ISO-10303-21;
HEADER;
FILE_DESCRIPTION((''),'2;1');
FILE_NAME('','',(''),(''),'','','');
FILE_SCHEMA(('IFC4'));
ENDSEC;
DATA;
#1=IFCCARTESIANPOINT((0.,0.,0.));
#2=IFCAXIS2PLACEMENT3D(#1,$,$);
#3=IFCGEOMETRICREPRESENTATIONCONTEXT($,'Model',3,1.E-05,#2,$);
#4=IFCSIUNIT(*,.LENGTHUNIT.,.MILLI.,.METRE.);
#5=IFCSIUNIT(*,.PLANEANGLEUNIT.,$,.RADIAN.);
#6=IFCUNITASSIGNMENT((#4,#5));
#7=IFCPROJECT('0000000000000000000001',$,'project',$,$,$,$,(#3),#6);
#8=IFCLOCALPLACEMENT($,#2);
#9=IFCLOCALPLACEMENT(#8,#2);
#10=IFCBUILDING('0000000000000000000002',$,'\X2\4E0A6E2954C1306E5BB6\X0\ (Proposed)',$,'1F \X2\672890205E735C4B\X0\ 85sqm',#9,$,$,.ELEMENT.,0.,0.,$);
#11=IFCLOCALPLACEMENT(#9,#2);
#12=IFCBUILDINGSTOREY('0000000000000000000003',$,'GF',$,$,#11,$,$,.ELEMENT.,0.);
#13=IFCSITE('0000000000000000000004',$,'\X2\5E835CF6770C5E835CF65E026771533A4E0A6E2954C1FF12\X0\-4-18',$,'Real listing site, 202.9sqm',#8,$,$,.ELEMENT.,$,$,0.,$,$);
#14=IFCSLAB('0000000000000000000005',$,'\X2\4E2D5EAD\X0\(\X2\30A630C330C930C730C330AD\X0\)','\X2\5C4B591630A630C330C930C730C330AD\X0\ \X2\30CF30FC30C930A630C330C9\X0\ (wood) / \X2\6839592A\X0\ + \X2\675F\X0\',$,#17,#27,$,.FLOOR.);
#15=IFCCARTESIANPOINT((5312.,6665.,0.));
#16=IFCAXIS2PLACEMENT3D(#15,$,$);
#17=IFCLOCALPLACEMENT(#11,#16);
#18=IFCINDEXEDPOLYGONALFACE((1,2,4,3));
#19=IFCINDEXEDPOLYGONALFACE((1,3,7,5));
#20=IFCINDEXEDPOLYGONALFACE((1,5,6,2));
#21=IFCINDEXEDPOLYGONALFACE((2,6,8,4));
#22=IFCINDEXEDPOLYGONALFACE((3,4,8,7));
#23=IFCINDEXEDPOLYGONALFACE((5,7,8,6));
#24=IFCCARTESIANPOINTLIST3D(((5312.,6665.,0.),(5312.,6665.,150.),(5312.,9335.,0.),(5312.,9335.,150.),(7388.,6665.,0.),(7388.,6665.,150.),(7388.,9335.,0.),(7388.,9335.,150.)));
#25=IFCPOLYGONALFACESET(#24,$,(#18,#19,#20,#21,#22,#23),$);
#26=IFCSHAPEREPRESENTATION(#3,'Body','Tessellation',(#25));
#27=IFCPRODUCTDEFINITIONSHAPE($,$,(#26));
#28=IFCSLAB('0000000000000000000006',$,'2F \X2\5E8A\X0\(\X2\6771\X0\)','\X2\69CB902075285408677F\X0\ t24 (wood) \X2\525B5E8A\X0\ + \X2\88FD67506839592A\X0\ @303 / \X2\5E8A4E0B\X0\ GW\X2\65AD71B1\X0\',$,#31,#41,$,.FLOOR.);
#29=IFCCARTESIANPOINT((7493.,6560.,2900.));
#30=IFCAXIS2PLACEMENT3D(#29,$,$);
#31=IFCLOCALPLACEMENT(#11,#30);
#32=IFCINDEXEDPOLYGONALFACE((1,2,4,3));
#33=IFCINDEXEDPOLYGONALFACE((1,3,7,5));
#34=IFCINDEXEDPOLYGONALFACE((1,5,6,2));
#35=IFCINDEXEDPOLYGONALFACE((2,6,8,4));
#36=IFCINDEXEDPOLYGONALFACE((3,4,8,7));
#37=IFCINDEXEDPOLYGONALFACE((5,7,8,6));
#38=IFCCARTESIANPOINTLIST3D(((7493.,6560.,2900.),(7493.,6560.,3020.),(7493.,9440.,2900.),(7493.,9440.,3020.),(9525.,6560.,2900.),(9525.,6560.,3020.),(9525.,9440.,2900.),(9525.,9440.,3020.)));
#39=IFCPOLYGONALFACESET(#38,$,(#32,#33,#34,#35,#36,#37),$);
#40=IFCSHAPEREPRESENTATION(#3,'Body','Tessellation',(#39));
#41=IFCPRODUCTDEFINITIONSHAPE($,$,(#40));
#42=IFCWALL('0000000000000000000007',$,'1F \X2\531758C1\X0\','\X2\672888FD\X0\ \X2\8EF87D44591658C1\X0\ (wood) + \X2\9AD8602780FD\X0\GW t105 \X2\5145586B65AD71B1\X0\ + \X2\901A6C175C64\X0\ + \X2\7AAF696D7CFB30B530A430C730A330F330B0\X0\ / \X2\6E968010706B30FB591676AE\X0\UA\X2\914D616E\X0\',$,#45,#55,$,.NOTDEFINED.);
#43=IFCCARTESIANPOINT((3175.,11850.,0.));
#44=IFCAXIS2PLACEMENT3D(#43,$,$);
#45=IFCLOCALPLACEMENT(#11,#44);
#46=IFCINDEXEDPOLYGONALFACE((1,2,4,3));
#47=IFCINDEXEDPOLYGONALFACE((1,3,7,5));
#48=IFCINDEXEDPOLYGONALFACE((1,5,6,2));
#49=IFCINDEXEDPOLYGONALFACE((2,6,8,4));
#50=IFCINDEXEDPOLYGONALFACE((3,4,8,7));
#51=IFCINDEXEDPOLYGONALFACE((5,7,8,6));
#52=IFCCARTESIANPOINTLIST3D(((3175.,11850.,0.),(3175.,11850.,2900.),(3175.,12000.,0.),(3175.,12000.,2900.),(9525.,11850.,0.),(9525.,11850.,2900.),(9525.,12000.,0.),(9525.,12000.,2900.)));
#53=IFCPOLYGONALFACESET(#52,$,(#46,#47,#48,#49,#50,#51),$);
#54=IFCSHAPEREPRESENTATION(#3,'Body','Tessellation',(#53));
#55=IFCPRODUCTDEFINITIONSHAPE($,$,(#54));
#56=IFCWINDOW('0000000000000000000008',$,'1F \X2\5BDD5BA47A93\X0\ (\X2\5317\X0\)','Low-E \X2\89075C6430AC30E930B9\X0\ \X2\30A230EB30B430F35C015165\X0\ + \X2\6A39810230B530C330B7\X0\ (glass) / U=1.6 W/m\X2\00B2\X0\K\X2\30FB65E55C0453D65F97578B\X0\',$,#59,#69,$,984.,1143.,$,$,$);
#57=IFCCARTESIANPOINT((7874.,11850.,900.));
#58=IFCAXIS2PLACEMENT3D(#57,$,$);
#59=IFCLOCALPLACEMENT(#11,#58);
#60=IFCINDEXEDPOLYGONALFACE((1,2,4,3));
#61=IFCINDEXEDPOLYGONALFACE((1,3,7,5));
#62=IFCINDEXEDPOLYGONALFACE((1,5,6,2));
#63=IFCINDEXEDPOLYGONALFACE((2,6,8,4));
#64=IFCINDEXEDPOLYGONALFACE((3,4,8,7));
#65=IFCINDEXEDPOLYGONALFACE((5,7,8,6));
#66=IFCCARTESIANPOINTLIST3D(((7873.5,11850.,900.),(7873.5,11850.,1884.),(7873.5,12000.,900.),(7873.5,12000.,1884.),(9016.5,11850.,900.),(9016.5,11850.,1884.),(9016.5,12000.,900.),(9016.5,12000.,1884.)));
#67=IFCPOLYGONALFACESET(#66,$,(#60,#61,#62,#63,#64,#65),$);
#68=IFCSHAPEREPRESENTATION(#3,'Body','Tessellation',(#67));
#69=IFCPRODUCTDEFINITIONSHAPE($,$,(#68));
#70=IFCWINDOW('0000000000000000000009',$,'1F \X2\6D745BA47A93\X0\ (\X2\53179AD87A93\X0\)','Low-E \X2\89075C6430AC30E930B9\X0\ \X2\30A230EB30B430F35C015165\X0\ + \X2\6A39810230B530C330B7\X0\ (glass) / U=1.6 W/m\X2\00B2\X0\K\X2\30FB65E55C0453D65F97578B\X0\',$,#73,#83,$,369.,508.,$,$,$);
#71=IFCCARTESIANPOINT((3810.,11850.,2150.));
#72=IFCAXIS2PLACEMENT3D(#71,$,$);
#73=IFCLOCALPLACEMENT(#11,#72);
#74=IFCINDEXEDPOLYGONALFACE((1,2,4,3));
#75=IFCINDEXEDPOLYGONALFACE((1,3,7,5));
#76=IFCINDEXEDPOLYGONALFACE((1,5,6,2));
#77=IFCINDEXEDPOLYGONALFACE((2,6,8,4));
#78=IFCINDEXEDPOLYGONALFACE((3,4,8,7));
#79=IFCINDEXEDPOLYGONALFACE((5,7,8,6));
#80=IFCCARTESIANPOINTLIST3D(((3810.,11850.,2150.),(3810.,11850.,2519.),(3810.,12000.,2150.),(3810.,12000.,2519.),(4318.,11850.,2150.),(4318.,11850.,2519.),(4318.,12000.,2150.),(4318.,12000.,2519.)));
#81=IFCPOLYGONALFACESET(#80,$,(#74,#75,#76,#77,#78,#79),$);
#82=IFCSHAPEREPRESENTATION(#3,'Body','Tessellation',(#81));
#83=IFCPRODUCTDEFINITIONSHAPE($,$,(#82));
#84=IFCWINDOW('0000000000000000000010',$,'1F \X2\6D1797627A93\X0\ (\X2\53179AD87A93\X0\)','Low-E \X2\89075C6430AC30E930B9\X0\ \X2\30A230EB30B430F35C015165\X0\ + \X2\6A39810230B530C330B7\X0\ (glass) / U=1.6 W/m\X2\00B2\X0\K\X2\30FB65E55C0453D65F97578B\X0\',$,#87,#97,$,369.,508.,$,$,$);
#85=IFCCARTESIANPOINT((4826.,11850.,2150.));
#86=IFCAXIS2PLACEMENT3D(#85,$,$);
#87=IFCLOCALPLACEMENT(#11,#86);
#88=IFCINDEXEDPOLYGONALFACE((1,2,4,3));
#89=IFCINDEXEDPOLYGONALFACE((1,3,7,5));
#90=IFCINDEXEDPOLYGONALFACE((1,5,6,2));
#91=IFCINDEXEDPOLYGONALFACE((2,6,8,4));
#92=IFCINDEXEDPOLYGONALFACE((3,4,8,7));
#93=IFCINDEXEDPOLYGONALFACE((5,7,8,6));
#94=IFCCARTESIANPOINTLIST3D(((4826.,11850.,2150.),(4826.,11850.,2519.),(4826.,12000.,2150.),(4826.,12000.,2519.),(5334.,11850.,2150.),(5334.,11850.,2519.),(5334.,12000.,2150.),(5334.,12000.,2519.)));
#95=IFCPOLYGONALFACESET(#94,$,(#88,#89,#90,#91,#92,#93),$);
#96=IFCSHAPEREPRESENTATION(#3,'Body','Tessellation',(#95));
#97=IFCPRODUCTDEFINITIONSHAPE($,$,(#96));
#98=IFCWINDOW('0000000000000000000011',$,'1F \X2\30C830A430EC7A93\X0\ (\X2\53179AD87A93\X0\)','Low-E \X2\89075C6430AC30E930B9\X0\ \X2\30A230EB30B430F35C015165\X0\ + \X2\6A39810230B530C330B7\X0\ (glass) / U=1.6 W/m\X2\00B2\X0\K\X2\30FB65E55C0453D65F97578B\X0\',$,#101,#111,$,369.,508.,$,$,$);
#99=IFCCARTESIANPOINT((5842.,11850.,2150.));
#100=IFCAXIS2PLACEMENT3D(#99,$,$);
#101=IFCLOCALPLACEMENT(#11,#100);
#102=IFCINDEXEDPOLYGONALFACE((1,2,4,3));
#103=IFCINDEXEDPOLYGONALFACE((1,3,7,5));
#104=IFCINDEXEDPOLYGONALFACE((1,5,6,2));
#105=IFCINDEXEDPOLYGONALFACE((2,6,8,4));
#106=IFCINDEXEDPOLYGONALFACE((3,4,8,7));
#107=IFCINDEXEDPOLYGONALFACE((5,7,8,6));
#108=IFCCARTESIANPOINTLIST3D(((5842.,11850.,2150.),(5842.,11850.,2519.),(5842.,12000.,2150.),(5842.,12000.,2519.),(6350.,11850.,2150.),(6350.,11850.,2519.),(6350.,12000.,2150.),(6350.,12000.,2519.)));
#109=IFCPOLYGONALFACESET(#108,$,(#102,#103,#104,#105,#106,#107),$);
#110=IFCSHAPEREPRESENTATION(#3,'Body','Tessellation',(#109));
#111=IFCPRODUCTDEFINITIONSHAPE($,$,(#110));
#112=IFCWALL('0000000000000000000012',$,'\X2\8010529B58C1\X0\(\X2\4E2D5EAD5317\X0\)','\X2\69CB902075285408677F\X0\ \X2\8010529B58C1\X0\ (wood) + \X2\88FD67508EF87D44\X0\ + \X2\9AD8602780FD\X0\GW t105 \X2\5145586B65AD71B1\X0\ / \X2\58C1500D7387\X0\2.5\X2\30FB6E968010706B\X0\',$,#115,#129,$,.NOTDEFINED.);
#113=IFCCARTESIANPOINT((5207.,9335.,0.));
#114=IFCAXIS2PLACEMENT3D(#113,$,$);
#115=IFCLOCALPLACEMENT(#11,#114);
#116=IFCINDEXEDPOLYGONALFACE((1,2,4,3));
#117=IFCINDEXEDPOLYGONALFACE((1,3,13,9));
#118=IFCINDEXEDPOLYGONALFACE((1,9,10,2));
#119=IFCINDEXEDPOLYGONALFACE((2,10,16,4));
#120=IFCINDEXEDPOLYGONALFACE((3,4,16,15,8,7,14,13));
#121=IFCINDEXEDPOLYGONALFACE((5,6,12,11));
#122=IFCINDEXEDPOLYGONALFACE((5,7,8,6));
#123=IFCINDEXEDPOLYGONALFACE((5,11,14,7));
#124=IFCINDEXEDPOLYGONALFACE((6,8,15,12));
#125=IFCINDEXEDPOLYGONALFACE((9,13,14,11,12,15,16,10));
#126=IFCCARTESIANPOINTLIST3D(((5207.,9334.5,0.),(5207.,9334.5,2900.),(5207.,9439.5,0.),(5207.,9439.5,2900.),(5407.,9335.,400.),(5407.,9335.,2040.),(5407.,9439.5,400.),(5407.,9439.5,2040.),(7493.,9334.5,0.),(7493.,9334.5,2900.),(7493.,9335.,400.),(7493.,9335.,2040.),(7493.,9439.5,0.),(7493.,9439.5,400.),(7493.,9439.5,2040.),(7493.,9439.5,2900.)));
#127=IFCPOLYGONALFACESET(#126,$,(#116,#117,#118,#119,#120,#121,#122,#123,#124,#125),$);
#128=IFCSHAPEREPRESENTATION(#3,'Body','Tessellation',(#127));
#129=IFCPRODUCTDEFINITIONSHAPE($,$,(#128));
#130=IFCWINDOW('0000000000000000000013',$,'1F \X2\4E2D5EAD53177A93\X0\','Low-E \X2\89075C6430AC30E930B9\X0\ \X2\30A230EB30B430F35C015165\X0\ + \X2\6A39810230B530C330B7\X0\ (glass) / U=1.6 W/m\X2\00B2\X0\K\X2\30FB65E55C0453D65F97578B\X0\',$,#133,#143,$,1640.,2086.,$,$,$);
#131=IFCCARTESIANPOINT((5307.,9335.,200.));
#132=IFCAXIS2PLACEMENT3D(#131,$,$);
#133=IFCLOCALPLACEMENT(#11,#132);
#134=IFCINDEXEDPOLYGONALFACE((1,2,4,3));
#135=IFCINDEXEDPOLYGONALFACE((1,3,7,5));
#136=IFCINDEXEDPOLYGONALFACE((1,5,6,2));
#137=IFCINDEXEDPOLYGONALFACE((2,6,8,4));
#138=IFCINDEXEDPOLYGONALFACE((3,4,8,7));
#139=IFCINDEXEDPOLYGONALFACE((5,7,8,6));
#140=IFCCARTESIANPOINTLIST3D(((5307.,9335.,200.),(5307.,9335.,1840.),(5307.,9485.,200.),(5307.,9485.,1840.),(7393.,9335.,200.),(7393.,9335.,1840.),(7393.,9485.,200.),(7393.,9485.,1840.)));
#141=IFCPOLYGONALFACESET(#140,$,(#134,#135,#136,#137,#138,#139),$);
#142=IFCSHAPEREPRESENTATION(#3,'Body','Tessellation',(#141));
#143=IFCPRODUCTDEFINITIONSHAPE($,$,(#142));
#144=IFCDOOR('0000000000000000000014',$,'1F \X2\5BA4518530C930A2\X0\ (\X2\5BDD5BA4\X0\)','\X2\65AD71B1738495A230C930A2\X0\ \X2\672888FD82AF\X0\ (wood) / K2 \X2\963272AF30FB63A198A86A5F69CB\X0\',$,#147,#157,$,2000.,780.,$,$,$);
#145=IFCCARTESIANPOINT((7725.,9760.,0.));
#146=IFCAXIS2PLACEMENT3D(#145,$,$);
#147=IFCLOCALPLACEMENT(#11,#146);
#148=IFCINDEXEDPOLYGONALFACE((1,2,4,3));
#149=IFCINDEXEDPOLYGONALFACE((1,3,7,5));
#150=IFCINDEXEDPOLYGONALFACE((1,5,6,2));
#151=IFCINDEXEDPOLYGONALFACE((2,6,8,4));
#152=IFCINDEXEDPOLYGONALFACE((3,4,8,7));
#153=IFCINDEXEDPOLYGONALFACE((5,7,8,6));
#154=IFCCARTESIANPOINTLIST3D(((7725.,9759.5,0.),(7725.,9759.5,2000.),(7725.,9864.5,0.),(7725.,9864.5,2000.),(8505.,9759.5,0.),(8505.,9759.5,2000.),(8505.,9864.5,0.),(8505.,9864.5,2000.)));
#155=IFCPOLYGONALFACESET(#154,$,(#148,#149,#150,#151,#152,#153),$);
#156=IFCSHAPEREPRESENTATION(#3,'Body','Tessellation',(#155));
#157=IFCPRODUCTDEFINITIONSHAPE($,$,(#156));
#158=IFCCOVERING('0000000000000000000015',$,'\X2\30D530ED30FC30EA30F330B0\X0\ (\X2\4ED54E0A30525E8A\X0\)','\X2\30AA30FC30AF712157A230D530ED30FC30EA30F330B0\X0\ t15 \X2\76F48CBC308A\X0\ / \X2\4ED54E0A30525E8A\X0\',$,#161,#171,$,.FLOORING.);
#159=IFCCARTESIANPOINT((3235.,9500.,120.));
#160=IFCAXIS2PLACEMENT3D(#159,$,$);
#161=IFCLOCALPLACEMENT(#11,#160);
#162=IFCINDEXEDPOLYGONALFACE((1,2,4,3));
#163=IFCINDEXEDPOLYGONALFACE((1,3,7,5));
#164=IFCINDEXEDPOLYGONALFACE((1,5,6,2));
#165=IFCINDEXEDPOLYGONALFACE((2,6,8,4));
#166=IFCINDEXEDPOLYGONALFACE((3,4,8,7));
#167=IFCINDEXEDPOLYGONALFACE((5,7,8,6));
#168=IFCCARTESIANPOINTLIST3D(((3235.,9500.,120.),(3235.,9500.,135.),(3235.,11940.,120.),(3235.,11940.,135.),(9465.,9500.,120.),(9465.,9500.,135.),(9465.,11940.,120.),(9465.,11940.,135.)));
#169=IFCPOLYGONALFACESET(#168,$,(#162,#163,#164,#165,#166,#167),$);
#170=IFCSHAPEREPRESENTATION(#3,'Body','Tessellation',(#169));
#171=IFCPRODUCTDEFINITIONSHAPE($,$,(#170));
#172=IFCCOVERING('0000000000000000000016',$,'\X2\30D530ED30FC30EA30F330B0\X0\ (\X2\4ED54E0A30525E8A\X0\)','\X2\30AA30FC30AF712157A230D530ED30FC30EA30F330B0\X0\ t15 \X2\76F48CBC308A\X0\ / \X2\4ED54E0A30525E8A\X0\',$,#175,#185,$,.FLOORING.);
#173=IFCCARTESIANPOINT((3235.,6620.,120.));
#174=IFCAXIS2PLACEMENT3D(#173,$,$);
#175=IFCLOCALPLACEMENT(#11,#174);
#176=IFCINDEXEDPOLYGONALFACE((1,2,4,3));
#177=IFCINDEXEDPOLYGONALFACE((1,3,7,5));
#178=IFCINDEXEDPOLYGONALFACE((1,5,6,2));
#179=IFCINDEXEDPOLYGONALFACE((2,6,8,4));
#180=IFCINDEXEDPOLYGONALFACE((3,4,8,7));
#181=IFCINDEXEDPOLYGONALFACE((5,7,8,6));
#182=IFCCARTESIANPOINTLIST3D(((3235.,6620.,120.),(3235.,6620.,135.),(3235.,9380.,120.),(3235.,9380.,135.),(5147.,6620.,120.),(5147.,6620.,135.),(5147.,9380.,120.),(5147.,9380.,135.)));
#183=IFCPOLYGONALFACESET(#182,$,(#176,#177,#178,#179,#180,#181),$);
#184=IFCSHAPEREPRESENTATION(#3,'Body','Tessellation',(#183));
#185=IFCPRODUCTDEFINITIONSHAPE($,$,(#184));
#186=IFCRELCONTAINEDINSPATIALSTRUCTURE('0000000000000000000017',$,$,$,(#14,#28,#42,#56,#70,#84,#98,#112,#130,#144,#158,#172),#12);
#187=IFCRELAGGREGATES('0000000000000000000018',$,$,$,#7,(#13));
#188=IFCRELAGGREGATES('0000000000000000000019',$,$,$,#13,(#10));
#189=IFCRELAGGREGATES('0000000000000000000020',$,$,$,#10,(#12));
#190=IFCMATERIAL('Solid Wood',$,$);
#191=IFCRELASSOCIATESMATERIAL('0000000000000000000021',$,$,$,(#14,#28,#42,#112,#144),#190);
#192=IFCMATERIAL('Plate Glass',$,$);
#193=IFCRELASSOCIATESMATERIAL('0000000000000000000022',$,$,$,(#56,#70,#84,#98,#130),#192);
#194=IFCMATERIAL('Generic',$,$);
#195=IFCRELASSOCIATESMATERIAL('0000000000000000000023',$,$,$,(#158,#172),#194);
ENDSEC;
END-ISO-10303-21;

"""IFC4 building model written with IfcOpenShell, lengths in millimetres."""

from ifc_helpers import new_model, si_unit, frame, frame_2d, origin, place, context, project, spatial, rectangle, extrude, material, element, fill, save


model = new_model("IFC4")

# Units and contexts
model_context = context("Model", 3, precision=1e-05, world=origin())
ifc_project = project(units=[si_unit("LENGTHUNIT", "METRE", prefix="MILLI"), si_unit("PLANEANGLEUNIT", "RADIAN")], contexts=[model_context])

# Site, building, storey
site_placement = place(None, origin())
site = spatial("IfcSite", under=ifc_project, at=site_placement, Name="広島県広島市東区上温品２-4-18", ObjectType="Real listing site, 202.9sqm", CompositionType="ELEMENT", RefElevation=0.0)
building_placement = place(site_placement, origin())
building = spatial("IfcBuilding", under=site, at=building_placement, Name="上温品の家 (Proposed)", ObjectType="1F 木造平屋 85sqm", CompositionType="ELEMENT", ElevationOfRefHeight=0.0, ElevationOfTerrain=0.0)
storey_placement = place(building_placement, origin())
storey = spatial("IfcBuildingStorey", under=building, at=storey_placement, Name="GF", CompositionType="ELEMENT", Elevation=0.0)

# Slabs
ifc_material_1 = material(Name="Solid Wood")
slab_1_placement = place(storey_placement, frame((5312.0, 6665.0, 0.0)))
element("IfcSlab", 1, at=slab_1_placement, inside=storey, material=ifc_material_1, Name="中庭(ウッドデッキ)", Description="屋外ウッドデッキ ハードウッド (wood) / 根太 + 束", PredefinedType="FLOOR", context=model_context, shape_type="SweptSolid", body=[
    extrude(rectangle(XDim=2076.0, YDim=2670.0, at=frame_2d((1038.0, 1335.0))), frame((5312.0, 6665.0, 0.0)), (0.0, 0.0, 1.0), 150.0),
])
slab_2_placement = place(storey_placement, frame((7493.0, 6560.0, 2900.0)))
element("IfcSlab", 2, at=slab_2_placement, inside=storey, material=ifc_material_1, Name="2F 床(東)", Description="構造用合板 t24 (wood) 剛床 + 製材根太 @303 / 床下 GW断熱", PredefinedType="FLOOR", context=model_context, shape_type="SweptSolid", body=[
    extrude(rectangle(XDim=2032.0, YDim=2880.0, at=frame_2d((1016.0, 1440.0))), frame((7493.0, 6560.0, 2900.0)), (0.0, 0.0, 1.0), 120.0),
])

# Wall, openings, windows
wall_1_placement = place(storey_placement, frame((3175.0, 11850.0, 0.0)))
wall_1 = element("IfcWall", 3, at=wall_1_placement, inside=storey, material=ifc_material_1, Name="1F 北壁", Description="木製 軸組外壁 (wood) + 高性能GW t105 充填断熱 + 通気層 + 窯業系サイディング / 準耐火・外皮UA配慮", PredefinedType="NOTDEFINED", context=model_context, shape_type="SweptSolid", body=[
    extrude(rectangle(XDim=6350.0, YDim=150.0, at=frame_2d((3175.0, 75.0))), frame((3175.0, 11850.0, 0.0)), (0.0, 0.0, 1.0), 2900.0),
])
opening_1_placement = place(storey_placement, frame((7874.0, 11850.0, 900.0)))
opening_1 = element("IfcOpeningElement", 4, at=opening_1_placement, cuts=wall_1, PredefinedType="NOTDEFINED", context=model_context, shape_type="SweptSolid", body=[
    extrude(rectangle(XDim=1143.0, YDim=150.0, at=frame_2d((571.0, 75.0))), frame((7874.0, 11850.0, 900.0)), (0.0, 0.0, 1.0), 984.0),
])
opening_2_placement = place(storey_placement, frame((3810.0, 11850.0, 2150.0)))
opening_2 = element("IfcOpeningElement", 5, at=opening_2_placement, cuts=wall_1, PredefinedType="NOTDEFINED", context=model_context, shape_type="SweptSolid", body=[
    extrude(rectangle(XDim=508.0, YDim=150.0, at=frame_2d((254.0, 75.0))), frame((3810.0, 11850.0, 2150.0)), (0.0, 0.0, 1.0), 369.0),
])
opening_3_placement = place(storey_placement, frame((4826.0, 11850.0, 2150.0)))
opening_3 = element("IfcOpeningElement", 6, at=opening_3_placement, cuts=wall_1, PredefinedType="NOTDEFINED", context=model_context, shape_type="SweptSolid", body=[
    extrude(rectangle(XDim=508.0, YDim=150.0, at=frame_2d((254.0, 75.0))), frame((4826.0, 11850.0, 2150.0)), (0.0, 0.0, 1.0), 369.0),
])
opening_4_placement = place(storey_placement, frame((5842.0, 11850.0, 2150.0)))
opening_4 = element("IfcOpeningElement", 7, at=opening_4_placement, cuts=wall_1, PredefinedType="NOTDEFINED", context=model_context, shape_type="SweptSolid", body=[
    extrude(rectangle(XDim=508.0, YDim=150.0, at=frame_2d((254.0, 75.0))), frame((5842.0, 11850.0, 2150.0)), (0.0, 0.0, 1.0), 369.0),
])
ifc_material_2 = material(Name="Plate Glass")
window_1_placement = place(storey_placement, frame((7874.0, 11850.0, 900.0)))
window_1 = element("IfcWindow", 8, at=window_1_placement, inside=storey, material=ifc_material_2, Name="1F 寝室窓 (北)", Description="Low-E 複層ガラス アルゴン封入 + 樹脂サッシ (glass) / U=1.6 W/m²K・日射取得型", OverallHeight=984.0, OverallWidth=1143.0, context=model_context, shape_type="SweptSolid", body=[
    extrude(rectangle(XDim=1143.0, YDim=150.0, at=frame_2d((571.0, 75.0))), frame((7874.0, 11850.0, 900.0)), (0.0, 0.0, 1.0), 984.0),
])
fill(opening_1, window_1)
window_2_placement = place(storey_placement, frame((3810.0, 11850.0, 2150.0)))
window_2 = element("IfcWindow", 9, at=window_2_placement, inside=storey, material=ifc_material_2, Name="1F 浴室窓 (北高窓)", Description="Low-E 複層ガラス アルゴン封入 + 樹脂サッシ (glass) / U=1.6 W/m²K・日射取得型", OverallHeight=369.0, OverallWidth=508.0, context=model_context, shape_type="SweptSolid", body=[
    extrude(rectangle(XDim=508.0, YDim=150.0, at=frame_2d((254.0, 75.0))), frame((3810.0, 11850.0, 2150.0)), (0.0, 0.0, 1.0), 369.0),
])
fill(opening_2, window_2)
window_3_placement = place(storey_placement, frame((4826.0, 11850.0, 2150.0)))
window_3 = element("IfcWindow", 10, at=window_3_placement, inside=storey, material=ifc_material_2, Name="1F 洗面窓 (北高窓)", Description="Low-E 複層ガラス アルゴン封入 + 樹脂サッシ (glass) / U=1.6 W/m²K・日射取得型", OverallHeight=369.0, OverallWidth=508.0, context=model_context, shape_type="SweptSolid", body=[
    extrude(rectangle(XDim=508.0, YDim=150.0, at=frame_2d((254.0, 75.0))), frame((4826.0, 11850.0, 2150.0)), (0.0, 0.0, 1.0), 369.0),
])
fill(opening_3, window_3)
window_4_placement = place(storey_placement, frame((5842.0, 11850.0, 2150.0)))
window_4 = element("IfcWindow", 11, at=window_4_placement, inside=storey, material=ifc_material_2, Name="1F トイレ窓 (北高窓)", Description="Low-E 複層ガラス アルゴン封入 + 樹脂サッシ (glass) / U=1.6 W/m²K・日射取得型", OverallHeight=369.0, OverallWidth=508.0, context=model_context, shape_type="SweptSolid", body=[
    extrude(rectangle(XDim=508.0, YDim=150.0, at=frame_2d((254.0, 75.0))), frame((5842.0, 11850.0, 2150.0)), (0.0, 0.0, 1.0), 369.0),
])
fill(opening_4, window_4)

# Wall, opening, window
wall_2_placement = place(storey_placement, frame((5207.0, 9335.0, 0.0)))
wall_2 = element("IfcWall", 12, at=wall_2_placement, inside=storey, material=ifc_material_1, Name="耐力壁(中庭北)", Description="構造用合板 耐力壁 (wood) + 製材軸組 + 高性能GW t105 充填断熱 / 壁倍率2.5・準耐火", PredefinedType="NOTDEFINED", context=model_context, shape_type="SweptSolid", body=[
    extrude(rectangle(XDim=2286.0, YDim=105.0, at=frame_2d((1143.0, 52.0))), frame((5207.0, 9335.0, 0.0)), (0.0, 0.0, 1.0), 2900.0),
])
opening_5_placement = place(storey_placement, frame((5307.0, 9335.0, 200.0)))
opening_5 = element("IfcOpeningElement", 13, at=opening_5_placement, cuts=wall_2, PredefinedType="NOTDEFINED", context=model_context, shape_type="SweptSolid", body=[
    extrude(rectangle(XDim=2086.0, YDim=150.0, at=frame_2d((1043.0, 75.0))), frame((5307.0, 9335.0, 200.0)), (0.0, 0.0, 1.0), 1640.0),
])
window_5_placement = place(storey_placement, frame((5307.0, 9335.0, 200.0)))
window_5 = element("IfcWindow", 14, at=window_5_placement, inside=storey, material=ifc_material_2, Name="1F 中庭北窓", Description="Low-E 複層ガラス アルゴン封入 + 樹脂サッシ (glass) / U=1.6 W/m²K・日射取得型", OverallHeight=1640.0, OverallWidth=2086.0, context=model_context, shape_type="SweptSolid", body=[
    extrude(rectangle(XDim=2086.0, YDim=150.0, at=frame_2d((1043.0, 75.0))), frame((5307.0, 9335.0, 200.0)), (0.0, 0.0, 1.0), 1640.0),
])
fill(opening_5, window_5)

# Door
door_1_placement = place(storey_placement, frame((7725.0, 9760.0, 0.0)))
element("IfcDoor", 15, at=door_1_placement, inside=storey, material=ifc_material_1, Name="1F 室内ドア (寝室)", Description="断熱玄関ドア 木製芯 (wood) / K2 防犯・採風機構", OverallHeight=2000.0, OverallWidth=780.0, context=model_context, shape_type="SweptSolid", body=[
    extrude(rectangle(XDim=780.0, YDim=105.0, at=frame_2d((390.0, 52.0))), frame((7725.0, 9760.0, 0.0)), (0.0, 0.0, 1.0), 2000.0),
])

# Coverings
ifc_material_3 = material(Name="Generic")
covering_1_placement = place(storey_placement, frame((3235.0, 9500.0, 120.0)))
element("IfcCovering", 16, at=covering_1_placement, inside=storey, material=ifc_material_3, Name="フローリング (仕上げ床)", Description="オーク無垢フローリング t15 直貼り / 仕上げ床", PredefinedType="FLOORING", context=model_context, shape_type="SweptSolid", body=[
    extrude(rectangle(XDim=6230.0, YDim=2440.0, at=frame_2d((3115.0, 1220.0))), frame((3235.0, 9500.0, 120.0)), (0.0, 0.0, 1.0), 15.0),
])
covering_2_placement = place(storey_placement, frame((3235.0, 6620.0, 120.0)))
element("IfcCovering", 17, at=covering_2_placement, inside=storey, material=ifc_material_3, Name="フローリング (仕上げ床)", Description="オーク無垢フローリング t15 直貼り / 仕上げ床", PredefinedType="FLOORING", context=model_context, shape_type="SweptSolid", body=[
    extrude(rectangle(XDim=1912.0, YDim=2760.0, at=frame_2d((956.0, 1380.0))), frame((3235.0, 6620.0, 120.0)), (0.0, 0.0, 1.0), 15.0),
])

save(model, "model.ifc")
